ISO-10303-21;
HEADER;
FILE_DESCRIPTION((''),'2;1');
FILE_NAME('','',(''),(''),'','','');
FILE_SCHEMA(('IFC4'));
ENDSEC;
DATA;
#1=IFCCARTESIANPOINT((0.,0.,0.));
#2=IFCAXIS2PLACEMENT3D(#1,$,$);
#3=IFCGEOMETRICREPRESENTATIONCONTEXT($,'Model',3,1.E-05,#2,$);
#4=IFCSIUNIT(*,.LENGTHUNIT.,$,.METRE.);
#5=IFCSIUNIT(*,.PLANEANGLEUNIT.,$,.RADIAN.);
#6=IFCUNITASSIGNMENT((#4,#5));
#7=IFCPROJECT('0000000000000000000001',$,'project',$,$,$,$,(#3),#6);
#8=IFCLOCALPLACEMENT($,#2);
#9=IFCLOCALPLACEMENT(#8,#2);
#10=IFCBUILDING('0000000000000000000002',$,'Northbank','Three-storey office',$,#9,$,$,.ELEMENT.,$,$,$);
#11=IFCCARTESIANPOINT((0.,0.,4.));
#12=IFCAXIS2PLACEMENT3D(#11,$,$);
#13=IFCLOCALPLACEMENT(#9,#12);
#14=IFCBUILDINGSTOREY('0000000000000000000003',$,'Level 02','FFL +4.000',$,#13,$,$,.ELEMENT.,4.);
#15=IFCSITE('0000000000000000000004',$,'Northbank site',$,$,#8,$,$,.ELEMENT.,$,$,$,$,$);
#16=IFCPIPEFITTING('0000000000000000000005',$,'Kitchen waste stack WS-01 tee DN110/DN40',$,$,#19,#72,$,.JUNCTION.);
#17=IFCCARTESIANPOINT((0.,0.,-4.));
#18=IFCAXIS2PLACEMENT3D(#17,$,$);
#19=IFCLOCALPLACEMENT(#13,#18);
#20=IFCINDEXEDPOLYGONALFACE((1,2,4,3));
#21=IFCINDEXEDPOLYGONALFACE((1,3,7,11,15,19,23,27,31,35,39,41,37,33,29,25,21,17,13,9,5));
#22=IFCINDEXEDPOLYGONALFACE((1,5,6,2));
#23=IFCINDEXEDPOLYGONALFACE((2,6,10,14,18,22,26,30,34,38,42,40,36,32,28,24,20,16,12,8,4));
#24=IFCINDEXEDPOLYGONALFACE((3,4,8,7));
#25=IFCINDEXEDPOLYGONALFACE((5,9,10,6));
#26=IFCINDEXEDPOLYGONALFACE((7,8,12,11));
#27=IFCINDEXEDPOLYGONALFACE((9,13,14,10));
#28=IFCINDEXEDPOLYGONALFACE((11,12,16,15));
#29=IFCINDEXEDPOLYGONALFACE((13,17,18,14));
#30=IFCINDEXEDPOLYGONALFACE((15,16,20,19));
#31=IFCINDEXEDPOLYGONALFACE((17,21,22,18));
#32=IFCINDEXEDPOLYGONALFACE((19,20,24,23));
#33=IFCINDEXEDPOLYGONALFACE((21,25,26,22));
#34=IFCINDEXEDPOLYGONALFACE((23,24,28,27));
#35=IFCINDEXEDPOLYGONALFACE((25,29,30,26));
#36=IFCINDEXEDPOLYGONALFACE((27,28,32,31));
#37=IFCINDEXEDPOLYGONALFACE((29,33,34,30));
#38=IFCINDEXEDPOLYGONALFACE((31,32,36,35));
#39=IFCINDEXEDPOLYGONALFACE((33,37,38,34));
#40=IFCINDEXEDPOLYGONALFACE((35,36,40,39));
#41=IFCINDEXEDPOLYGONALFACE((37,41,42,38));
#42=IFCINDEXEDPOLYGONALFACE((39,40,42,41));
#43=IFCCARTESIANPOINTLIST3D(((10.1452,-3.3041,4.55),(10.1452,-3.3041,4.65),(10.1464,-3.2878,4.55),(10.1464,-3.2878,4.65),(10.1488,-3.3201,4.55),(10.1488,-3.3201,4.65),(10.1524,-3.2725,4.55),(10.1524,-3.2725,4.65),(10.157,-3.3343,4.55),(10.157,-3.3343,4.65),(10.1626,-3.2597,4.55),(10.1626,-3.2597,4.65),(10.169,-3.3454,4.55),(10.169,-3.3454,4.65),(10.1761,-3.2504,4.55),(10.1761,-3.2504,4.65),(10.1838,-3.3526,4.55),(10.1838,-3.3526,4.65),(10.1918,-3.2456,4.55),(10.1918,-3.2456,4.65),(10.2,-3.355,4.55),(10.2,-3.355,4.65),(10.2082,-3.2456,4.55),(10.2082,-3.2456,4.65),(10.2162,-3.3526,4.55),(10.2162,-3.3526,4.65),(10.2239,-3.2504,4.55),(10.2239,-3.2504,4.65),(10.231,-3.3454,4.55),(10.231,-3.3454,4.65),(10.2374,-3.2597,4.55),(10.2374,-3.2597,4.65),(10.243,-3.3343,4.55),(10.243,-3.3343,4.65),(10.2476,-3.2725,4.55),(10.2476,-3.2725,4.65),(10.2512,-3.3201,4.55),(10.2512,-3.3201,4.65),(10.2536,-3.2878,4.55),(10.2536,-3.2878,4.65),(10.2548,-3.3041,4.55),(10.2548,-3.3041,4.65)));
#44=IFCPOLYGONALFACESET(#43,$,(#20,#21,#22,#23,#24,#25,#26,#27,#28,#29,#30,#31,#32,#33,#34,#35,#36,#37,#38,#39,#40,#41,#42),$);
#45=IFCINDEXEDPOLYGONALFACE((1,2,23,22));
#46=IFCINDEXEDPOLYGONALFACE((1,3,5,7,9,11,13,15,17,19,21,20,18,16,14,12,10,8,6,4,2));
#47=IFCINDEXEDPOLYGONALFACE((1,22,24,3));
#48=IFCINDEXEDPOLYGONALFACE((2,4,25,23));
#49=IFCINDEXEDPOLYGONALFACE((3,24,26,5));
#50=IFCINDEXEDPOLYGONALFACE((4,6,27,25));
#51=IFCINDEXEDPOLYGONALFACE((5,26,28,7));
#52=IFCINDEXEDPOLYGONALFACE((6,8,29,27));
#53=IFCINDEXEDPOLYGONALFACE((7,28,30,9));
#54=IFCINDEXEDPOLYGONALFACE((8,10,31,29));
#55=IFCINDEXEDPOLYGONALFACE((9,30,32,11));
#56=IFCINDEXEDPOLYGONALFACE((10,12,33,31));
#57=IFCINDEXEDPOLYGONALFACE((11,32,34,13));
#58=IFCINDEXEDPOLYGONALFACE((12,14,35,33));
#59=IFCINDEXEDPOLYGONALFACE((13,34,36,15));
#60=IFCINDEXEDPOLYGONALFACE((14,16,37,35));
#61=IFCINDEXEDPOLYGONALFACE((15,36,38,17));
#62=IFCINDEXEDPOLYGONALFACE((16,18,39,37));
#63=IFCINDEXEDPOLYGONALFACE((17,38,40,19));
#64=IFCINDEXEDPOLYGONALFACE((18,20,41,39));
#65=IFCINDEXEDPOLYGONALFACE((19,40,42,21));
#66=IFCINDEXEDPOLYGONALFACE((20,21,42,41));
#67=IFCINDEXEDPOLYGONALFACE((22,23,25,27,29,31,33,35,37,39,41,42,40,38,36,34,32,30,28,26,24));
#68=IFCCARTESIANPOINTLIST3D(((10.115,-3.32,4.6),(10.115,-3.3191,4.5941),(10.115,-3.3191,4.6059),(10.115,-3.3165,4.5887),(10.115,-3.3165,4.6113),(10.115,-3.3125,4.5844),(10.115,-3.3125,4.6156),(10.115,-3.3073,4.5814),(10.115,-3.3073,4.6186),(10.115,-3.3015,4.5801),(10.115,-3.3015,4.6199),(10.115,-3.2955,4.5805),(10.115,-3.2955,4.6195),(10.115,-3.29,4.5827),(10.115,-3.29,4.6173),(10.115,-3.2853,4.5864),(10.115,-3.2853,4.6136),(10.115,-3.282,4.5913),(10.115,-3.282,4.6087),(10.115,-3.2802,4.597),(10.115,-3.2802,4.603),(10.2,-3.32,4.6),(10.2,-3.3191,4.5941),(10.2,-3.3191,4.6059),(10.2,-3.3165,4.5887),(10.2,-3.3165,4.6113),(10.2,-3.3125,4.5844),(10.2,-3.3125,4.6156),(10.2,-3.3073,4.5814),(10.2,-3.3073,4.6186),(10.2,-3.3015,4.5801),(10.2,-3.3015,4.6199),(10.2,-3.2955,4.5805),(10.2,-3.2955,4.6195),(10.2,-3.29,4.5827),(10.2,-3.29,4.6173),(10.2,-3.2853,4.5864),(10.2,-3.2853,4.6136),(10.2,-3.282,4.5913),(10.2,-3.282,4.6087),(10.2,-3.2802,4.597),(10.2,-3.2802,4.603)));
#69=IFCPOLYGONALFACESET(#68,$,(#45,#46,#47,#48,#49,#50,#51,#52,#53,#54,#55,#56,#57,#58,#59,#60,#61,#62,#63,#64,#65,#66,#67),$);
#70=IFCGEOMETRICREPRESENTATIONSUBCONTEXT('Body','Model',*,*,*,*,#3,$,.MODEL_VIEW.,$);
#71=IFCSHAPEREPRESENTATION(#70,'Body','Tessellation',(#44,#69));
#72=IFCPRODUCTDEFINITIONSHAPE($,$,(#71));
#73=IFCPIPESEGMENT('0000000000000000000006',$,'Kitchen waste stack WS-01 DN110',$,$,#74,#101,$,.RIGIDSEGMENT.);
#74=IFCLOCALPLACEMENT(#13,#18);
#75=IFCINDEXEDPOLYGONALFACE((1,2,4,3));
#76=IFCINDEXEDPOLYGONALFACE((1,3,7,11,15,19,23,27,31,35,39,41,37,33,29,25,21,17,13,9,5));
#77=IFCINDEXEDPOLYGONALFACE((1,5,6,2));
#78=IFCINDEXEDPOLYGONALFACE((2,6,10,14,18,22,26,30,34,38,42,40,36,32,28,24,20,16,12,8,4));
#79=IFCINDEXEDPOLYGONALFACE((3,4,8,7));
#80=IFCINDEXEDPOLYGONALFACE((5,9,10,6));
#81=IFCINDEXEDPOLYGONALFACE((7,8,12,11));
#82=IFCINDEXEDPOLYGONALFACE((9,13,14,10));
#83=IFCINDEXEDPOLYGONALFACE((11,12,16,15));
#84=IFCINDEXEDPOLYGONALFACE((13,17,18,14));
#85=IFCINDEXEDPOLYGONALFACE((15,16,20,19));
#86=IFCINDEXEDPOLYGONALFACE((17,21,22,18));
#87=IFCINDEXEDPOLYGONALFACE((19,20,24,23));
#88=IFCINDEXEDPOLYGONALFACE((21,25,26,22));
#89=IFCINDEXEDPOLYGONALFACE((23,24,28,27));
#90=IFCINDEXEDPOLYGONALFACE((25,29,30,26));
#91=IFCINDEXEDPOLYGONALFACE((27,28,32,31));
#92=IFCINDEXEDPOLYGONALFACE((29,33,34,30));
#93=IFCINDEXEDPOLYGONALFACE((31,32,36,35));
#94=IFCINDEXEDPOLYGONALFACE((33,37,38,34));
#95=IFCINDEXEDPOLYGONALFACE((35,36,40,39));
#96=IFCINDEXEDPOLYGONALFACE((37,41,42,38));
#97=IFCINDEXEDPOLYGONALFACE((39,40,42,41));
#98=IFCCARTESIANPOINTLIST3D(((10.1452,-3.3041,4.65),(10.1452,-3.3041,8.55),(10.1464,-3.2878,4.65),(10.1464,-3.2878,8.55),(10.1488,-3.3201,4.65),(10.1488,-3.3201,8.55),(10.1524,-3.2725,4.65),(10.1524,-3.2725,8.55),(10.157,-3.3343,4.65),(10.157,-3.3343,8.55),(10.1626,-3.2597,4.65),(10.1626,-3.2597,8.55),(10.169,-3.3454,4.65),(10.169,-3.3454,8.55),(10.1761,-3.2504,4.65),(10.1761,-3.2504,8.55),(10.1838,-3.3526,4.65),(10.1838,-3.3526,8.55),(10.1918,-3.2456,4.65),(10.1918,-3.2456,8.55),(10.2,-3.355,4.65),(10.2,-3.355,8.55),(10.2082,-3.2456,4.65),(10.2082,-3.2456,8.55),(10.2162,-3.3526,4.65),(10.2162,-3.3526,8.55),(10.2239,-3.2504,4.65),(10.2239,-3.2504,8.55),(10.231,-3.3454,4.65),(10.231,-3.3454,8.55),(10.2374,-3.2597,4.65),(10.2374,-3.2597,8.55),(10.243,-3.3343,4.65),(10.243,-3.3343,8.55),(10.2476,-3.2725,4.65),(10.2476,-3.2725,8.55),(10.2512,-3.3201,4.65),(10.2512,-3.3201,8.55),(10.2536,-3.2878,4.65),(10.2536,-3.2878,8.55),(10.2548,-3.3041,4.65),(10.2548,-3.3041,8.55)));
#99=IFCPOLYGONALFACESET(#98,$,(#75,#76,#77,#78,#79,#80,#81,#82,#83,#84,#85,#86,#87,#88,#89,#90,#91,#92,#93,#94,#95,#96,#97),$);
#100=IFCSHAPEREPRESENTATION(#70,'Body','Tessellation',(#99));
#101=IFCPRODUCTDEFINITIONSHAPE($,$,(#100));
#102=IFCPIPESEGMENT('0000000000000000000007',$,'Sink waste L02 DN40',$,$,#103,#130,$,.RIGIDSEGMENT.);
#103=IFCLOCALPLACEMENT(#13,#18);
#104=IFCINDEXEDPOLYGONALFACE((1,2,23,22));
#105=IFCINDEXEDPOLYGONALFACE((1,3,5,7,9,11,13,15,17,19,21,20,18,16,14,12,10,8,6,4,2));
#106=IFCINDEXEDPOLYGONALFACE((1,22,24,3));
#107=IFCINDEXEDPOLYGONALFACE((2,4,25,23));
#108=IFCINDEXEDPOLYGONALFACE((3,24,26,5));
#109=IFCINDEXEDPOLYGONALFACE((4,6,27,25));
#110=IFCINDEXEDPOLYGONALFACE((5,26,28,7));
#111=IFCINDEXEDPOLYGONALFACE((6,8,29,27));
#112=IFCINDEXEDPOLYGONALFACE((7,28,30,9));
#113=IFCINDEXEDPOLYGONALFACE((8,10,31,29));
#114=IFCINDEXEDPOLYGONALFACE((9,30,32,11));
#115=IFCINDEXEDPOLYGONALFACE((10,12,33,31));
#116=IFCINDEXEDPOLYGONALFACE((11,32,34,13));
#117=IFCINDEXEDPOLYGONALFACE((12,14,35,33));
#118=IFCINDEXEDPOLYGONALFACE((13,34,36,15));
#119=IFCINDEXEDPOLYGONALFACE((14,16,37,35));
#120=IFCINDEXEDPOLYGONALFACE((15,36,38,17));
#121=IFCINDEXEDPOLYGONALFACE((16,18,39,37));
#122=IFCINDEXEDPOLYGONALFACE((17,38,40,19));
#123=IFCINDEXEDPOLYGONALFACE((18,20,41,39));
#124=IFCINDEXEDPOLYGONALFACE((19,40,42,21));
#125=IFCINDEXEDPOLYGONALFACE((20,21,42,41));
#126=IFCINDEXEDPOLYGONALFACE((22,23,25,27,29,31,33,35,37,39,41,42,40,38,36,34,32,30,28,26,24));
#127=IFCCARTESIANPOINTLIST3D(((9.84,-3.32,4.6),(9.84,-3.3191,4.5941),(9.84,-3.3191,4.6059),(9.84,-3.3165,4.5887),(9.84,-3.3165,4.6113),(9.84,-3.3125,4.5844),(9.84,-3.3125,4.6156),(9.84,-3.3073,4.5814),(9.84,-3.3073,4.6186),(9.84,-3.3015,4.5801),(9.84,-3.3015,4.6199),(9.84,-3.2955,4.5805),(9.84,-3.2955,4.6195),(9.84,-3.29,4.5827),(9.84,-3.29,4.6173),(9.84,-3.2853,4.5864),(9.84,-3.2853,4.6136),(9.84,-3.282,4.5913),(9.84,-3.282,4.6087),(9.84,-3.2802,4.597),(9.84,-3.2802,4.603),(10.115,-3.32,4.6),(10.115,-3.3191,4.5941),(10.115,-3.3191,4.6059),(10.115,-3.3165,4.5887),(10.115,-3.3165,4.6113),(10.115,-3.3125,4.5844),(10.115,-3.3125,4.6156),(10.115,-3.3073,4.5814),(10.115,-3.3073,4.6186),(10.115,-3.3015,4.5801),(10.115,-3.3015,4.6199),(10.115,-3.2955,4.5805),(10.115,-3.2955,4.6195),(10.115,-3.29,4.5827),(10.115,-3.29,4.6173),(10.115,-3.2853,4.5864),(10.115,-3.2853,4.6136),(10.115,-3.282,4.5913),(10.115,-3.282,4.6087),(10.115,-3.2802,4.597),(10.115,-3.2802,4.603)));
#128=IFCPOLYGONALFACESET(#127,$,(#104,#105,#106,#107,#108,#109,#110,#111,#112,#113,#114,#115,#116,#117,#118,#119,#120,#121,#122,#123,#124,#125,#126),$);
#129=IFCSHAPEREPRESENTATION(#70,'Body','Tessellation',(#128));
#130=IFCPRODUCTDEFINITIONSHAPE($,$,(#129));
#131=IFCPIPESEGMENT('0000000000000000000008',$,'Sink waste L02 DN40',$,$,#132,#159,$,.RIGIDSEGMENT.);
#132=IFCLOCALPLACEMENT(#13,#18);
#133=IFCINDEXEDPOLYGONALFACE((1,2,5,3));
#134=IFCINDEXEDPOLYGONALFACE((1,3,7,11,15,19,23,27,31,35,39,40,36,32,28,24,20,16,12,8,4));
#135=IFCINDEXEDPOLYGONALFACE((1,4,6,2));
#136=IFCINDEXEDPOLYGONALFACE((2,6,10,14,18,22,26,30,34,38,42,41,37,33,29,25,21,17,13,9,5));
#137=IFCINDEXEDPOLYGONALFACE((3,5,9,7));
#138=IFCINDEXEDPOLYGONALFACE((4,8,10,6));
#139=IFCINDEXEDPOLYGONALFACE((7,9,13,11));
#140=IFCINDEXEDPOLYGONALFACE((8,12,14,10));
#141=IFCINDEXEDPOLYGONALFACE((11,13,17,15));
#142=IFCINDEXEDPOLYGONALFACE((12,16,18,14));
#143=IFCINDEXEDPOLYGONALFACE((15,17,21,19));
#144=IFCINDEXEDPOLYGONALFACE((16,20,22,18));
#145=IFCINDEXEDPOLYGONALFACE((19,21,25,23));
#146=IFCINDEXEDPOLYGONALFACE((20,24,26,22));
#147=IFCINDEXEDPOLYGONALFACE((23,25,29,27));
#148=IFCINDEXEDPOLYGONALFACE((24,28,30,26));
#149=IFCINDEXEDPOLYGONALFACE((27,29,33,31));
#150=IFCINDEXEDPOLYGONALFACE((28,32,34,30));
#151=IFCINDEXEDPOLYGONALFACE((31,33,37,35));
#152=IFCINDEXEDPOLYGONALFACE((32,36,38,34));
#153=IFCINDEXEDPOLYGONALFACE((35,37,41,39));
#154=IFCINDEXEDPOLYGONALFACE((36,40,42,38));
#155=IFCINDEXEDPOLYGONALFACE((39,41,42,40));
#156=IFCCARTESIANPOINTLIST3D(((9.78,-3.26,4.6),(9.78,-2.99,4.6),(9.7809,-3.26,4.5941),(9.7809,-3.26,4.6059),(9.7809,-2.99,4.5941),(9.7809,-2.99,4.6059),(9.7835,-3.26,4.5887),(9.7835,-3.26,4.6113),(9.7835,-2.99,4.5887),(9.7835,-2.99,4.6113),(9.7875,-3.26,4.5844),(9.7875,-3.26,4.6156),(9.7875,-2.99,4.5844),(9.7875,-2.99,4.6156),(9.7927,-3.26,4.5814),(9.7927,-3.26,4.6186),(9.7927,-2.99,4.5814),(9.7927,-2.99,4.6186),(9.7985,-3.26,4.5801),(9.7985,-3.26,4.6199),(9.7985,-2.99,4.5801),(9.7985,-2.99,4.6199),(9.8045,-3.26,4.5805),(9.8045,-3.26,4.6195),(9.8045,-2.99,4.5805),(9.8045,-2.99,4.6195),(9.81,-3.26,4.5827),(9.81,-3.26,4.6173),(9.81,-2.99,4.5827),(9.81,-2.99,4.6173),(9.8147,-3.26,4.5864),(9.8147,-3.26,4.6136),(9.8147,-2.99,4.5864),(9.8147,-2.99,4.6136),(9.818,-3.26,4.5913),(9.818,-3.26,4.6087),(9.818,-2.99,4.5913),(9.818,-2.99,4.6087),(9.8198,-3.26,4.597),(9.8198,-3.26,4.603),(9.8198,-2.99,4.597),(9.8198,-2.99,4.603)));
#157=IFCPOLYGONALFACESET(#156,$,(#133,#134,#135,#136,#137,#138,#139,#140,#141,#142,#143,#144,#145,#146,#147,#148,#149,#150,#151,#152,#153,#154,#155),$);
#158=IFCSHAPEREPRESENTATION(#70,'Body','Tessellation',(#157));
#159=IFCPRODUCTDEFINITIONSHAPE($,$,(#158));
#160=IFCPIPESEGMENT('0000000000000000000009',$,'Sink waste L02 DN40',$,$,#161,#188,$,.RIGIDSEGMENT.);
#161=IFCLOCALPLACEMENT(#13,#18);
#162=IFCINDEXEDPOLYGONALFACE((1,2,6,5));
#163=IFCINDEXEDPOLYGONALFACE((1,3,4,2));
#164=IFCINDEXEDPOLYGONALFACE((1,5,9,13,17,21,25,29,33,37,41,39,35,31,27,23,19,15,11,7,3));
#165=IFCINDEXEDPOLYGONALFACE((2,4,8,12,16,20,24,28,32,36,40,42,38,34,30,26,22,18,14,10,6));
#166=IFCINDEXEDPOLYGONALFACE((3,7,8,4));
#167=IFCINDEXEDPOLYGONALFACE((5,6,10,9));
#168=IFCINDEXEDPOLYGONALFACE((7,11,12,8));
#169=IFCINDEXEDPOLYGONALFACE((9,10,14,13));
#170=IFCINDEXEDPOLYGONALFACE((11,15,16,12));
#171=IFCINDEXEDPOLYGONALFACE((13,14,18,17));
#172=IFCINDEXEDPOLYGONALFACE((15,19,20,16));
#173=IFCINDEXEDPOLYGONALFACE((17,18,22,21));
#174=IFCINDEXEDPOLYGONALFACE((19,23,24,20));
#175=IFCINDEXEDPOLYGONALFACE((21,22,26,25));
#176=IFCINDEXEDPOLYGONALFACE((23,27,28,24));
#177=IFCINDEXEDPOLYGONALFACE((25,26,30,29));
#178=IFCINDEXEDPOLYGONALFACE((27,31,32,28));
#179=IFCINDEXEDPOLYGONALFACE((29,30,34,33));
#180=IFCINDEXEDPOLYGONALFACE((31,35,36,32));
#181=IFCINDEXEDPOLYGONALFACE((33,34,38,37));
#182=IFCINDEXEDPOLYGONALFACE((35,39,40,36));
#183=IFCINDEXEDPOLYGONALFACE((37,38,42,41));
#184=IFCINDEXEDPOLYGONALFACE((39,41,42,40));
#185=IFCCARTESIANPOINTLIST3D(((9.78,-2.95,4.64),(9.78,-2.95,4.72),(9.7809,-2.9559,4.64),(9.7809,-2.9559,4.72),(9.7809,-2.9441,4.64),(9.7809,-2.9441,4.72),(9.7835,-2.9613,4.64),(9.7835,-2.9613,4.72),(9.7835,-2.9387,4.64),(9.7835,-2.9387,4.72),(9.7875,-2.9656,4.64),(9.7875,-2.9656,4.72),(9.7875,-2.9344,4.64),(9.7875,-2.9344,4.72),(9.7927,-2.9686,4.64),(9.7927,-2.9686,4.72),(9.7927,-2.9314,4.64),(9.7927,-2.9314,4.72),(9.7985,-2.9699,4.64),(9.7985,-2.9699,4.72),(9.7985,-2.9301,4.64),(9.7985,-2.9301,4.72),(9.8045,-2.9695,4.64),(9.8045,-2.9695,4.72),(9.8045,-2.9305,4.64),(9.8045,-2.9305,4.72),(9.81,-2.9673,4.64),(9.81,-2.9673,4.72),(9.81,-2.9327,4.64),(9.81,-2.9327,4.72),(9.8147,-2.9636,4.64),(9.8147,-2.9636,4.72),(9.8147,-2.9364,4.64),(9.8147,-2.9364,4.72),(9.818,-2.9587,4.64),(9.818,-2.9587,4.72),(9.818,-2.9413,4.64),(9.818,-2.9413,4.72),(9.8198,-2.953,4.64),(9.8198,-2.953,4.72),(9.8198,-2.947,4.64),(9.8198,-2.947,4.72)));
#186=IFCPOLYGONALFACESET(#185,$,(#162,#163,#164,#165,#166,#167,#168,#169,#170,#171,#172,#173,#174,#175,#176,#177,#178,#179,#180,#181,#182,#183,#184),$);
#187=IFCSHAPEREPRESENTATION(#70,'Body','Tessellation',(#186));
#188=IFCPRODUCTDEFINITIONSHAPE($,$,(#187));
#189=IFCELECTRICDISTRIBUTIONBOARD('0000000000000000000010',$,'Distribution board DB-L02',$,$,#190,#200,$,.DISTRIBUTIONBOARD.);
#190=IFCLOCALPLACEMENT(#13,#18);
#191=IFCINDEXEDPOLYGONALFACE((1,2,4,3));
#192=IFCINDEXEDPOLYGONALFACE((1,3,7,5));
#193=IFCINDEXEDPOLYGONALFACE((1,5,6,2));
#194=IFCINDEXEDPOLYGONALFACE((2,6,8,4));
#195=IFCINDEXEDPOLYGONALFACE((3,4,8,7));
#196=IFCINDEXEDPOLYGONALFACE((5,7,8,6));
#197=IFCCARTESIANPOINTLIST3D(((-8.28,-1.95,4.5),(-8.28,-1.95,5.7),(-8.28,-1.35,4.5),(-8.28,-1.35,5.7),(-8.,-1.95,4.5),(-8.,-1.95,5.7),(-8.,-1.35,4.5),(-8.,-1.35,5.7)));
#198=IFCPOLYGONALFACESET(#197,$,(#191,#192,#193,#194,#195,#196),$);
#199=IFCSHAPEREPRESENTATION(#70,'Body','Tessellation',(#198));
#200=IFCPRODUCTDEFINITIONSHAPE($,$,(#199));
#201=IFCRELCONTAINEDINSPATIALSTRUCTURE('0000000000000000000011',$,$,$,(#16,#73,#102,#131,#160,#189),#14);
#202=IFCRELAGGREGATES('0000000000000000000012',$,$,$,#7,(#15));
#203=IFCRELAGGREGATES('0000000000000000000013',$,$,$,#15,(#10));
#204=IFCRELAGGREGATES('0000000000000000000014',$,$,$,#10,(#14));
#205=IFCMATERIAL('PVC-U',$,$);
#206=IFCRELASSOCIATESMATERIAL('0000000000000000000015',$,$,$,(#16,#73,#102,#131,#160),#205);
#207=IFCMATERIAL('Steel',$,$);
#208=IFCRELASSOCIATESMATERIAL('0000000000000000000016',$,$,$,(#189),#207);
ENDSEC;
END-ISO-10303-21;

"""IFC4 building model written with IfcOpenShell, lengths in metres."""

from ifc_helpers import new_model, si_unit, frame, origin, place, context, subcontext, project, spatial, rectangle, circle, extrude, material, element, save


model = new_model("IFC4")

# Units and contexts
model_context = context("Model", 3, precision=1e-05, world=origin())
body_context = subcontext(model_context, "Body", "Model", "MODEL_VIEW")
ifc_project = project(units=[si_unit("LENGTHUNIT", "METRE"), si_unit("PLANEANGLEUNIT", "RADIAN")], contexts=[model_context])

# Site, building, storey
site_placement = place(None, origin())
site = spatial("IfcSite", under=ifc_project, at=site_placement, Name="Northbank site", CompositionType="ELEMENT")
building_placement = place(site_placement, origin())
building = spatial("IfcBuilding", under=site, at=building_placement, Name="Northbank", Description="Three-storey office", CompositionType="ELEMENT")
storey_placement = place(building_placement, frame((0.0, 0.0, 4.0)))
storey = spatial("IfcBuildingStorey", under=building, at=storey_placement, Name="Level 02", Description="FFL +4.000", CompositionType="ELEMENT", Elevation=4.0)

# Shared definitions
ifc_material_1 = material(Name="PVC-U")

# Pipe fitting
pipe_fitting_1_placement = place(storey_placement, frame((0.0, 0.0, -4.0)))
element("IfcPipeFitting", 1, at=pipe_fitting_1_placement, inside=storey, material=ifc_material_1, Name="Kitchen waste stack WS-01 tee DN110/DN40", PredefinedType="JUNCTION", context=body_context, shape_type="SweptSolid", body=[
    extrude(circle(Radius=0.055), frame((10.2, -3.3, 4.55), z_axis=(0.0, 0.0, 1.0), x_axis=(0.0, -1.0, 0.0)), (0.0, 0.0, 1.0), 0.1),
    extrude(circle(Radius=0.02), frame((10.2, -3.3, 4.6), z_axis=(-1.0, 0.0, 0.0), x_axis=(0.0, -1.0, 0.0)), (0.0, 0.0, 1.0), 0.085),
])

# Pipe segments
pipe_segment_1_placement = place(storey_placement, frame((0.0, 0.0, -4.0)))
element("IfcPipeSegment", 2, at=pipe_segment_1_placement, inside=storey, material=ifc_material_1, Name="Kitchen waste stack WS-01 DN110", PredefinedType="RIGIDSEGMENT", context=body_context, shape_type="SweptSolid", body=[
    extrude(circle(Radius=0.055), frame((10.2, -3.3, 4.65), z_axis=(0.0, 0.0, 1.0), x_axis=(0.0, -1.0, 0.0)), (0.0, 0.0, 1.0), 3.9),
])
pipe_segment_2_placement = place(storey_placement, frame((0.0, 0.0, -4.0)))
element("IfcPipeSegment", 3, at=pipe_segment_2_placement, inside=storey, material=ifc_material_1, Name="Sink waste L02 DN40", PredefinedType="RIGIDSEGMENT", context=body_context, shape_type="SweptSolid", body=[
    extrude(circle(Radius=0.02), frame((10.115, -3.3, 4.6), z_axis=(-1.0, 0.0, 0.0), x_axis=(0.0, -1.0, 0.0)), (0.0, 0.0, 1.0), 0.275),
])
pipe_segment_3_placement = place(storey_placement, frame((0.0, 0.0, -4.0)))
element("IfcPipeSegment", 4, at=pipe_segment_3_placement, inside=storey, material=ifc_material_1, Name="Sink waste L02 DN40", PredefinedType="RIGIDSEGMENT", context=body_context, shape_type="SweptSolid", body=[
    extrude(circle(Radius=0.02), frame((9.8, -3.26, 4.6), z_axis=(0.0, 1.0, 0.0), x_axis=(-1.0, 0.0, 0.0)), (0.0, 0.0, 1.0), 0.27),
])
pipe_segment_4_placement = place(storey_placement, frame((0.0, 0.0, -4.0)))
element("IfcPipeSegment", 5, at=pipe_segment_4_placement, inside=storey, material=ifc_material_1, Name="Sink waste L02 DN40", PredefinedType="RIGIDSEGMENT", context=body_context, shape_type="SweptSolid", body=[
    extrude(circle(Radius=0.02), frame((9.8, -2.95, 4.64), z_axis=(0.0, 0.0, 1.0), x_axis=(-1.0, 0.0, 0.0)), (0.0, 0.0, 1.0), 0.08),
])

# Electric distribution board
ifc_material_2 = material(Name="Steel")
electric_distribution_board_placement = place(storey_placement, frame((0.0, 0.0, -4.0)))
element("IfcElectricDistributionBoard", 6, at=electric_distribution_board_placement, inside=storey, material=ifc_material_2, Name="Distribution board DB-L02", PredefinedType="DISTRIBUTIONBOARD", context=body_context, shape_type="SweptSolid", body=[
    extrude(rectangle(XDim=0.28, YDim=0.6), frame((-8.14, -1.65, 4.5)), (0.0, 0.0, 1.0), 1.2),
])

save(model, "model.ifc")
